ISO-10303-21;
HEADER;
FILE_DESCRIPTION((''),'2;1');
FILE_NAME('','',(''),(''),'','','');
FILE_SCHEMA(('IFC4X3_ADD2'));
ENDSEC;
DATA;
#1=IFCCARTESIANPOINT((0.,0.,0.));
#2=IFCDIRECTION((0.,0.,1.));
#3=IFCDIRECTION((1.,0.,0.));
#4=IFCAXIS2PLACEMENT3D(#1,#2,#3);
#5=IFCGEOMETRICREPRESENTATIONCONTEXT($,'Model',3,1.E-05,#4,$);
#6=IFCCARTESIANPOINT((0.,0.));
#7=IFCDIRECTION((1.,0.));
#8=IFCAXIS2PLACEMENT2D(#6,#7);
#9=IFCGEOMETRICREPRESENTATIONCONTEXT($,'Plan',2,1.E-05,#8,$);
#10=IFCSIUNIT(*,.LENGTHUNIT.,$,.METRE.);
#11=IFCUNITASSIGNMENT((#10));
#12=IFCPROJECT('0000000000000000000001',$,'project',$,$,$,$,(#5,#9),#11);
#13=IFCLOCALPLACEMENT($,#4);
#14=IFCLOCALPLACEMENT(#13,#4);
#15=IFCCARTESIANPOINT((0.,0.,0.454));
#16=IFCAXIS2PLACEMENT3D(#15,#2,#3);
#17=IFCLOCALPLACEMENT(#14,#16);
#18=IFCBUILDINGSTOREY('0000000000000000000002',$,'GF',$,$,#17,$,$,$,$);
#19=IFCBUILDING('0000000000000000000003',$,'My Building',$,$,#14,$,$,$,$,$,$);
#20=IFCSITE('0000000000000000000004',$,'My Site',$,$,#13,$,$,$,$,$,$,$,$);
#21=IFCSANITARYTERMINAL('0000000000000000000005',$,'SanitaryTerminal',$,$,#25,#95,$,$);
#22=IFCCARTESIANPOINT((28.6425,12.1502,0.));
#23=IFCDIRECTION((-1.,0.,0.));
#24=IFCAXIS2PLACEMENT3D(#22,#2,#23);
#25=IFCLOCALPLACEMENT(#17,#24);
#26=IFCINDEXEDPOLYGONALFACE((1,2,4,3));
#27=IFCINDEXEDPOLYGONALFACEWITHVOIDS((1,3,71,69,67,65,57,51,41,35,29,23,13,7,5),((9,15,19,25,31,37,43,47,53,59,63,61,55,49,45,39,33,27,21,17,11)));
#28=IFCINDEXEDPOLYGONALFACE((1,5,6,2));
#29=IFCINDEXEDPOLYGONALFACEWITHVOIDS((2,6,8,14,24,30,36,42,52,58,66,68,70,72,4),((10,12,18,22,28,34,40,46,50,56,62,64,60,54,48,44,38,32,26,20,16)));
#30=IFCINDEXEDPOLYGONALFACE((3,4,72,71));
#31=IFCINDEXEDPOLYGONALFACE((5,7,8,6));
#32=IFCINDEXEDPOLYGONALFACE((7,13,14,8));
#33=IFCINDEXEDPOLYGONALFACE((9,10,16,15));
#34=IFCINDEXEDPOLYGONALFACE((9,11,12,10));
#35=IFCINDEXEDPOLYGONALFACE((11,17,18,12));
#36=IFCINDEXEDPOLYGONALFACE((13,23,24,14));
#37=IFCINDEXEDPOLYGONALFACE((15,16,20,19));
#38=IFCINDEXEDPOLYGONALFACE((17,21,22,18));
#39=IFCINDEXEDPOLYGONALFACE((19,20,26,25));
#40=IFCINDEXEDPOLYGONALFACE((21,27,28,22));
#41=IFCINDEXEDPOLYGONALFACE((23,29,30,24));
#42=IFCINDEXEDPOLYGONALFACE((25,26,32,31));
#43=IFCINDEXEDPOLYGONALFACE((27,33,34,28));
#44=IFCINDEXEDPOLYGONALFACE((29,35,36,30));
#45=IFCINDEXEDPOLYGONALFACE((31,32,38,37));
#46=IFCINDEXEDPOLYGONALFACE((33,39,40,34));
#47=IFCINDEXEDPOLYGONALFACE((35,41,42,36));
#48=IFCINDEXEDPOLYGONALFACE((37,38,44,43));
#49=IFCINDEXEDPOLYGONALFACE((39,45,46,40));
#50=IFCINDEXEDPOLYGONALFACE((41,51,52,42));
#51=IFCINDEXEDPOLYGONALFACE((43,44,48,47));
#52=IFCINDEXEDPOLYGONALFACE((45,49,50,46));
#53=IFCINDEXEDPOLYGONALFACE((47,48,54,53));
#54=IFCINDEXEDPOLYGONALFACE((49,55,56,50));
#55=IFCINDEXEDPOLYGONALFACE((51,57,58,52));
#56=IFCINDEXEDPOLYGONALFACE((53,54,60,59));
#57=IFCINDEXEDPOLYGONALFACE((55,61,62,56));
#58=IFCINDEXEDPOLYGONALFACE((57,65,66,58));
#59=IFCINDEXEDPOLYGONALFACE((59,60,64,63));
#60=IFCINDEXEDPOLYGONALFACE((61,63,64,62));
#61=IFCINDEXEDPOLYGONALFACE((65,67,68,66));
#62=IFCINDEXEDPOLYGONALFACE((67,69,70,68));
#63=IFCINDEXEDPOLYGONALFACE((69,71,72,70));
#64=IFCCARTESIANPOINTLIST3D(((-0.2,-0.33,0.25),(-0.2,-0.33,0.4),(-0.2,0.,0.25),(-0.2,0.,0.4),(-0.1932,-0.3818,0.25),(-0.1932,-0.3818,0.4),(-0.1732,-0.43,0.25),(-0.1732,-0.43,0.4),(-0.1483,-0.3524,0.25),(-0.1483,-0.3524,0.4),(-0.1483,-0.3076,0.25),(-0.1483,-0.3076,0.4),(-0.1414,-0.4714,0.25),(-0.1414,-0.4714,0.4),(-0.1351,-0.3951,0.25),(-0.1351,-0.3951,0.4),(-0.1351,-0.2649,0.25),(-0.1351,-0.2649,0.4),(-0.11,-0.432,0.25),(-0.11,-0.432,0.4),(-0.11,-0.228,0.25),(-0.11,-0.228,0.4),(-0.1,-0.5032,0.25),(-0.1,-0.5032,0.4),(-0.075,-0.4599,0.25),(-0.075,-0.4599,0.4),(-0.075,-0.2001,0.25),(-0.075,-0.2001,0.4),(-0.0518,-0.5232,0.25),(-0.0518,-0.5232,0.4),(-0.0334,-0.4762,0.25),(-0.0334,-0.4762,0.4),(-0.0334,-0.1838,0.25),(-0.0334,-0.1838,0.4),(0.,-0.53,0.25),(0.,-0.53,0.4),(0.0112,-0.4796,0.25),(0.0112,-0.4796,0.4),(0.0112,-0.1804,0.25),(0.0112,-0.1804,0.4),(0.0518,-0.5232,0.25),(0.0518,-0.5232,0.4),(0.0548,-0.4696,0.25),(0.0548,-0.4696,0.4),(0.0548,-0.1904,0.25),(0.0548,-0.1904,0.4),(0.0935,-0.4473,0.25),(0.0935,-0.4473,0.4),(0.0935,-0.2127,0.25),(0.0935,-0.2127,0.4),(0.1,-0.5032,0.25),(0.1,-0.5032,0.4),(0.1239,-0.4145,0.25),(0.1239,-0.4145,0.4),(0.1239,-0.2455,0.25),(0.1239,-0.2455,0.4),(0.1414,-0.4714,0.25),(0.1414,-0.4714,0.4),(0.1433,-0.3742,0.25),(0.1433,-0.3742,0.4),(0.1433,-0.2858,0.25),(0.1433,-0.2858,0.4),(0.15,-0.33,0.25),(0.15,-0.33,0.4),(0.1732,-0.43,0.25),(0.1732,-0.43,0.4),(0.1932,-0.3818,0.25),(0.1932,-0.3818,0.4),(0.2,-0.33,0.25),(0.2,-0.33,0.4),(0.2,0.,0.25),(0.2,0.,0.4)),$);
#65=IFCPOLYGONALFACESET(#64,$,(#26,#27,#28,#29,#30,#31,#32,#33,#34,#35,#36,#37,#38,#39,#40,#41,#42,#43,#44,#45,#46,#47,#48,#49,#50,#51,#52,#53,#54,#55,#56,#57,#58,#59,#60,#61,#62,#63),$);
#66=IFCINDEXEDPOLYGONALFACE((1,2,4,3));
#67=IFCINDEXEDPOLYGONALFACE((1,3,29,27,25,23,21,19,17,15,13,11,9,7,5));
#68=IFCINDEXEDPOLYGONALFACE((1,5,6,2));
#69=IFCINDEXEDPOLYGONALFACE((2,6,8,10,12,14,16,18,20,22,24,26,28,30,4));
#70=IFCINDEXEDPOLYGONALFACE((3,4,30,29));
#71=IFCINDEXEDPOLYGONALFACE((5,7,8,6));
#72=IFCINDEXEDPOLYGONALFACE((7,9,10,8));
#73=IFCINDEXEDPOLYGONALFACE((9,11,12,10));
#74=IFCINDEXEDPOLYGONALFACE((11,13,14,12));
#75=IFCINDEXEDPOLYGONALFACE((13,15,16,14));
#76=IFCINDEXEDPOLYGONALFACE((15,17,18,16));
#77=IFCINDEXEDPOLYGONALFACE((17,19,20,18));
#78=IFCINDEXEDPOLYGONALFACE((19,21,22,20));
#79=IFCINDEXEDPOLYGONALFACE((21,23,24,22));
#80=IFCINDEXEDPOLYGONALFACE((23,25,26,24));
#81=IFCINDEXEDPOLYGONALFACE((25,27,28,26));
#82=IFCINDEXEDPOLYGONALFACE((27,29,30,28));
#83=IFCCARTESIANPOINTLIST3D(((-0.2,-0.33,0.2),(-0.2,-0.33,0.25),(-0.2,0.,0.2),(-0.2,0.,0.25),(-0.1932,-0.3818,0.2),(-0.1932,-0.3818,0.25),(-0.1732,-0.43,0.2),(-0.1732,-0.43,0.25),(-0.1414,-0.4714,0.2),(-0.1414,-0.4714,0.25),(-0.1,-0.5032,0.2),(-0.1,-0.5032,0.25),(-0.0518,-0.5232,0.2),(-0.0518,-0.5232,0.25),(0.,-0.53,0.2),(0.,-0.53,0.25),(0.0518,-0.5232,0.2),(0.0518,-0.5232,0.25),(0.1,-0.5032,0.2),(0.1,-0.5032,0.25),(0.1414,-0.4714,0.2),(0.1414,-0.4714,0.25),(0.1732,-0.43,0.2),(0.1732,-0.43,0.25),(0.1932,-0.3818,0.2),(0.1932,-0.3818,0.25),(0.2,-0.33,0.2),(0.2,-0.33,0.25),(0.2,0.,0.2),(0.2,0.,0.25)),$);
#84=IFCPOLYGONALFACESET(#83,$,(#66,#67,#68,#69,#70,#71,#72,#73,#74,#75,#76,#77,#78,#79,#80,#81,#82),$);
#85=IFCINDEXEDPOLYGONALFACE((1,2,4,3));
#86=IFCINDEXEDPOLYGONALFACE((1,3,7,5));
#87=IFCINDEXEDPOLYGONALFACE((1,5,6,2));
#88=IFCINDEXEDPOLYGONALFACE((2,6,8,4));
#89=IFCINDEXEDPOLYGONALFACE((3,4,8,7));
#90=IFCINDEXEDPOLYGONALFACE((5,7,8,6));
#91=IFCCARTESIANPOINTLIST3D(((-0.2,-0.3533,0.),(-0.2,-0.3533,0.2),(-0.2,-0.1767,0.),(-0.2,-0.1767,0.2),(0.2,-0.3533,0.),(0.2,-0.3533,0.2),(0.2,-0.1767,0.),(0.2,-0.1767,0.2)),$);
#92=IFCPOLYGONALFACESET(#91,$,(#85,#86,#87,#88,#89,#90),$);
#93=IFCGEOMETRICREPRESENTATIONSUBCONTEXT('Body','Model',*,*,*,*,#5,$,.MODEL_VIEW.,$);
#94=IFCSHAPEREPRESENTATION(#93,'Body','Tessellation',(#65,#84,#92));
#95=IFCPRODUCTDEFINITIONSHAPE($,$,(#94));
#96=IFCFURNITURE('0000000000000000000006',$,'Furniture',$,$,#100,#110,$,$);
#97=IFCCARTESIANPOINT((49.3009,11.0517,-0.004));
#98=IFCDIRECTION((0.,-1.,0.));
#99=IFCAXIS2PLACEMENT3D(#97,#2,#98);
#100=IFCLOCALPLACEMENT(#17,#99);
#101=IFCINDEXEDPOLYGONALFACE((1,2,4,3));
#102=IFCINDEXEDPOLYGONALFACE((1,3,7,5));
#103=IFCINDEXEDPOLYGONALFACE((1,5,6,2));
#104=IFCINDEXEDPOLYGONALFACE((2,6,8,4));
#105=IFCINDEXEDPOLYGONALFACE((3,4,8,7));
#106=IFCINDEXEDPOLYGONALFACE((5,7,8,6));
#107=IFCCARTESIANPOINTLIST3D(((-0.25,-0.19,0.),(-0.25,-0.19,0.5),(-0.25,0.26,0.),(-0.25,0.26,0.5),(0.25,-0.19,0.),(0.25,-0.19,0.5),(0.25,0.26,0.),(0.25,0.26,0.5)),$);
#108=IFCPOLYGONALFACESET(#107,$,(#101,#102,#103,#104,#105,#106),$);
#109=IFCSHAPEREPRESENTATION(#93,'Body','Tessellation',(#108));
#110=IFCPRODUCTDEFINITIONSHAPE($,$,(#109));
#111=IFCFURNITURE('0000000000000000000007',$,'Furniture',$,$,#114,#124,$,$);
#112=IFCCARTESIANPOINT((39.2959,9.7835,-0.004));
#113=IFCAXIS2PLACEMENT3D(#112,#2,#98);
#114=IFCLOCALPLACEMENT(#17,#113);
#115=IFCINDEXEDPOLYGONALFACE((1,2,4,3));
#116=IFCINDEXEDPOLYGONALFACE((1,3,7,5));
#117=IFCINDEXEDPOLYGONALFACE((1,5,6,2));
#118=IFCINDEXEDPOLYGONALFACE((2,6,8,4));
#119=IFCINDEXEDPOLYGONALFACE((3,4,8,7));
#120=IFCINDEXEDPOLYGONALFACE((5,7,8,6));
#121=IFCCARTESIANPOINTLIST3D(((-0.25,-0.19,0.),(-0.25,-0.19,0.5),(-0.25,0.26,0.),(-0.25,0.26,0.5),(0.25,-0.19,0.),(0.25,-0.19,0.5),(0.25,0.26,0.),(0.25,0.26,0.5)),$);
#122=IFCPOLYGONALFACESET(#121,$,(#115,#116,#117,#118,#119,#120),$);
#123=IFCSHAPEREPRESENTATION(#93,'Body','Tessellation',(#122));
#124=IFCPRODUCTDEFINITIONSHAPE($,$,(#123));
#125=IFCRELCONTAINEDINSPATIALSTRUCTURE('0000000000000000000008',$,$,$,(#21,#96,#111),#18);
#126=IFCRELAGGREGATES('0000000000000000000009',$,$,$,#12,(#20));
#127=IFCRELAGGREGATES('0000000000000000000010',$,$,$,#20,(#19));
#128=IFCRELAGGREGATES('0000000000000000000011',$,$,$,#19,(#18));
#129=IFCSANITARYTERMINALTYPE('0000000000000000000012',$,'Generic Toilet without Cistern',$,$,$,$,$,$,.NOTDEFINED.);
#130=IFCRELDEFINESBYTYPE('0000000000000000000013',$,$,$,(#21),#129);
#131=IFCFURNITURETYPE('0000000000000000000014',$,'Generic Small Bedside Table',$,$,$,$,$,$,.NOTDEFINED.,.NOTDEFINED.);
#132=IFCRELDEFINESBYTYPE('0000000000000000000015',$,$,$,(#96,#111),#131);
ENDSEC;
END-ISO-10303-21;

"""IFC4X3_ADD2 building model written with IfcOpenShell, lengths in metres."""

from ifc_helpers import new_model, entity, si_unit, frame, frame_2d, origin_with_axes, origin_2d_with_axis, place, context, subcontext, project, spatial, line, arc, indexed_curve, circle_curve, outline, extrude, shape, source, transform, mapped, type_object, type_shapes, element, save


model = new_model("IFC4X3_ADD2")

# Units and contexts
model_context = context("Model", 3, precision=1e-05, world=origin_with_axes())
plan_context = context("Plan", 2, precision=1e-05, world=origin_2d_with_axis())
body_context_1 = subcontext(model_context, "Body", "Model", "MODEL_VIEW")
body_context_2 = subcontext(plan_context, "Body", "Plan", "PLAN_VIEW")
ifc_project = project(units=[si_unit("LENGTHUNIT", "METRE")], contexts=[model_context, plan_context])

# Site, building, storey
site_placement = place(None, origin_with_axes())
site = spatial("IfcSite", under=ifc_project, at=site_placement, Name="My Site")
building_placement = place(site_placement, origin_with_axes())
building = spatial("IfcBuilding", under=site, at=building_placement, Name="My Building")
storey_placement = place(building_placement, frame((0.0, 0.0, 0.454), z_axis=(0.0, 0.0, 1.0), x_axis=(1.0, 0.0, 0.0)))
storey = spatial("IfcBuildingStorey", under=building, at=storey_placement, Name="GF")

# Sanitary terminal
sanitary_terminal_type = type_object("IfcSanitaryTerminalType", Name="Generic Toilet without Cistern", PredefinedType="NOTDEFINED")
shared_shape_1 = source(origin_with_axes(), body_context_1, "Body", "SweptSolid", [
    extrude(outline(indexed_curve([(-0.2, 0.0), (0.2, 0.0), (0.2, -0.33), (0.1414, -0.4714), (0.0, -0.53), (-0.1414, -0.4714), (-0.2, -0.33)], segments=[line(1, 2), line(2, 3), arc(3, 4, 5), arc(5, 6, 7), line(7, 1)]), holes=[circle_curve(frame_2d((0.0, -0.33)), 0.15)]), frame((0.0, 0.0, 0.25), z_axis=(0.0, 0.0, 1.0), x_axis=(1.0, 0.0, 0.0)), (0.0, 0.0, 1.0), 0.15),
    extrude(outline(indexed_curve([(-0.2, 0.0), (0.2, 0.0), (0.2, -0.33), (0.1414, -0.4714), (0.0, -0.53), (-0.1414, -0.4714), (-0.2, -0.33)], segments=[line(1, 2), line(2, 3), arc(3, 4, 5), arc(5, 6, 7), line(7, 1)])), frame((0.0, 0.0, 0.2), z_axis=(0.0, 0.0, 1.0), x_axis=(1.0, 0.0, 0.0)), (0.0, 0.0, 1.0), 0.05),
    extrude(outline(indexed_curve([(-0.2, -0.1767), (0.2, -0.1767), (0.2, -0.3533), (-0.2, -0.3533)], segments=[line(1, 2, 3, 4, 1)])), origin_with_axes(), (0.0, 0.0, 1.0), 0.2),
])
shared_shape_2 = source(origin_with_axes(), body_context_2, "Body", "Annotation2D", [
    entity("IfcGeometricCurveSet", [entity("IfcIndexedPolyCurve", entity("IfcCartesianPointList2D", [[-0.1068, -0.124], [-0.0957, -0.1129], [-0.0804, -0.1088], [0.0804, -0.1088], [0.0957, -0.1129], [0.1068, -0.124], [0.1109, -0.1393], [0.1109, -0.3476], [0.1025, -0.3926], [0.0784, -0.4308], [0.0424, -0.4563], [0.0, -0.4652], [-0.0424, -0.4563], [-0.0784, -0.4308], [-0.1025, -0.3926], [-0.1109, -0.3476], [-0.1109, -0.1393]]), [entity("IfcLineIndex", [1, 2, 3, 4, 5, 6, 7, 8, 9, 10, 11, 12, 13, 14, 15, 16, 17, 1])]), entity("IfcIndexedPolyCurve", entity("IfcCartesianPointList2D", [[-0.1962, -0.2314], [-0.1848, -0.301], [-0.1764, -0.3339], [-0.1663, -0.3651], [-0.1546, -0.3944], [-0.1414, -0.4213], [-0.1269, -0.4458], [-0.1111, -0.4675], [-0.0943, -0.4862], [-0.0765, -0.5018], [-0.0581, -0.514], [-0.039, -0.5229], [-0.0196, -0.5282], [0.0, -0.53], [0.0196, -0.5282], [0.039, -0.5229], [0.0581, -0.514], [0.0765, -0.5018], [0.0943, -0.4862], [0.1111, -0.4675], [0.1269, -0.4458], [0.1414, -0.4213], [0.1546, -0.3944], [0.1663, -0.3651], [0.1764, -0.3339], [0.1848, -0.301], [0.1962, -0.2314], [0.2, -0.159], [0.1872, 0.0], [-0.1872, 0.0], [-0.2, -0.159]]), [entity("IfcLineIndex", [1, 2, 3, 4, 5, 6, 7, 8, 9, 10, 11, 12, 13, 14, 15, 16, 17, 18, 19, 20, 21, 22, 23, 24, 25, 26, 27, 28, 29, 30, 31, 1])])]),
])
type_shapes(sanitary_terminal_type, [shared_shape_1, shared_shape_2])
sanitary_terminal_placement = place(storey_placement, frame((28.6425, 12.1502, 0.0), z_axis=(0.0, 0.0, 1.0), x_axis=(-1.0, 0.0, 0.0)))
element("IfcSanitaryTerminal", 1, at=sanitary_terminal_placement, inside=storey, type_object=sanitary_terminal_type, Name="SanitaryTerminal", shapes=[
    shape(body_context_1, "Body", "MappedRepresentation", [mapped(shared_shape_1, transform((0.0, 0.0, 0.0), x_axis=(1.0, 0.0, 0.0), y_axis=(0.0, 1.0, 0.0), z_axis=(0.0, 0.0, 1.0), scale=1.0))]),
    shape(body_context_2, "Body", "MappedRepresentation", [mapped(shared_shape_2, transform((0.0, 0.0, 0.0), x_axis=(1.0, 0.0, 0.0), y_axis=(0.0, 1.0, 0.0), z_axis=(0.0, 0.0, 1.0), scale=1.0))]),
])

# Furniture
furniture_type_1 = type_object("IfcFurnitureType", Name="Generic Small Bedside Table", AssemblyPlace="NOTDEFINED", PredefinedType="NOTDEFINED")
shared_shape_3 = source(origin_with_axes(), body_context_1, "Body", "SweptSolid", [
    extrude(outline(indexed_curve([(0.5, 0.45), (0.5, 0.0), (0.0, 0.0), (0.0, 0.45)], segments=[line(4, 1), line(1, 2), line(2, 3), line(3, 4)], self_intersect=False)), frame((-0.25, -0.19, 0.0), z_axis=(0.0, 0.0, 1.0), x_axis=(1.0, 0.0, 0.0)), (0.0, 0.0, 1.0), 0.5),
])
shared_shape_4 = source(origin_with_axes(), body_context_2, "Body", "Annotation2D", [
    entity("IfcGeometricCurveSet", [entity("IfcIndexedPolyCurve", entity("IfcCartesianPointList2D", [[-0.25, -0.19], [0.25, -0.19], [0.25, 0.26], [-0.25, 0.26]]), [entity("IfcLineIndex", [1, 2]), entity("IfcLineIndex", [2, 3]), entity("IfcLineIndex", [3, 4]), entity("IfcLineIndex", [4, 1])])]),
])
type_shapes(furniture_type_1, [shared_shape_3, shared_shape_4])
for number, where, z_axis, x_axis, name in (
    (2, (49.3009, 11.0517, -0.004), (0.0, 0.0, 1.0), (0.0, -1.0, 0.0), "Furniture"),
    (3, (39.2959, 9.7835, -0.004), (0.0, 0.0, 1.0), (0.0, -1.0, 0.0), "Furniture"),
):
    element("IfcFurniture", number, at=place(storey_placement, frame(where, z_axis=z_axis, x_axis=x_axis)), inside=storey, type_object=furniture_type_1, Name=name, shapes=[
        shape(body_context_1, "Body", "MappedRepresentation", [mapped(shared_shape_3, transform((0.0, 0.0, 0.0), x_axis=(1.0, 0.0, 0.0), y_axis=(0.0, 1.0, 0.0), z_axis=(0.0, 0.0, 1.0), scale=1.0))]),
        shape(body_context_2, "Body", "MappedRepresentation", [mapped(shared_shape_4, transform((0.0, 0.0, 0.0), x_axis=(1.0, 0.0, 0.0), y_axis=(0.0, 1.0, 0.0), z_axis=(0.0, 0.0, 1.0), scale=1.0))]),
    ])

save(model, "model.ifc")
